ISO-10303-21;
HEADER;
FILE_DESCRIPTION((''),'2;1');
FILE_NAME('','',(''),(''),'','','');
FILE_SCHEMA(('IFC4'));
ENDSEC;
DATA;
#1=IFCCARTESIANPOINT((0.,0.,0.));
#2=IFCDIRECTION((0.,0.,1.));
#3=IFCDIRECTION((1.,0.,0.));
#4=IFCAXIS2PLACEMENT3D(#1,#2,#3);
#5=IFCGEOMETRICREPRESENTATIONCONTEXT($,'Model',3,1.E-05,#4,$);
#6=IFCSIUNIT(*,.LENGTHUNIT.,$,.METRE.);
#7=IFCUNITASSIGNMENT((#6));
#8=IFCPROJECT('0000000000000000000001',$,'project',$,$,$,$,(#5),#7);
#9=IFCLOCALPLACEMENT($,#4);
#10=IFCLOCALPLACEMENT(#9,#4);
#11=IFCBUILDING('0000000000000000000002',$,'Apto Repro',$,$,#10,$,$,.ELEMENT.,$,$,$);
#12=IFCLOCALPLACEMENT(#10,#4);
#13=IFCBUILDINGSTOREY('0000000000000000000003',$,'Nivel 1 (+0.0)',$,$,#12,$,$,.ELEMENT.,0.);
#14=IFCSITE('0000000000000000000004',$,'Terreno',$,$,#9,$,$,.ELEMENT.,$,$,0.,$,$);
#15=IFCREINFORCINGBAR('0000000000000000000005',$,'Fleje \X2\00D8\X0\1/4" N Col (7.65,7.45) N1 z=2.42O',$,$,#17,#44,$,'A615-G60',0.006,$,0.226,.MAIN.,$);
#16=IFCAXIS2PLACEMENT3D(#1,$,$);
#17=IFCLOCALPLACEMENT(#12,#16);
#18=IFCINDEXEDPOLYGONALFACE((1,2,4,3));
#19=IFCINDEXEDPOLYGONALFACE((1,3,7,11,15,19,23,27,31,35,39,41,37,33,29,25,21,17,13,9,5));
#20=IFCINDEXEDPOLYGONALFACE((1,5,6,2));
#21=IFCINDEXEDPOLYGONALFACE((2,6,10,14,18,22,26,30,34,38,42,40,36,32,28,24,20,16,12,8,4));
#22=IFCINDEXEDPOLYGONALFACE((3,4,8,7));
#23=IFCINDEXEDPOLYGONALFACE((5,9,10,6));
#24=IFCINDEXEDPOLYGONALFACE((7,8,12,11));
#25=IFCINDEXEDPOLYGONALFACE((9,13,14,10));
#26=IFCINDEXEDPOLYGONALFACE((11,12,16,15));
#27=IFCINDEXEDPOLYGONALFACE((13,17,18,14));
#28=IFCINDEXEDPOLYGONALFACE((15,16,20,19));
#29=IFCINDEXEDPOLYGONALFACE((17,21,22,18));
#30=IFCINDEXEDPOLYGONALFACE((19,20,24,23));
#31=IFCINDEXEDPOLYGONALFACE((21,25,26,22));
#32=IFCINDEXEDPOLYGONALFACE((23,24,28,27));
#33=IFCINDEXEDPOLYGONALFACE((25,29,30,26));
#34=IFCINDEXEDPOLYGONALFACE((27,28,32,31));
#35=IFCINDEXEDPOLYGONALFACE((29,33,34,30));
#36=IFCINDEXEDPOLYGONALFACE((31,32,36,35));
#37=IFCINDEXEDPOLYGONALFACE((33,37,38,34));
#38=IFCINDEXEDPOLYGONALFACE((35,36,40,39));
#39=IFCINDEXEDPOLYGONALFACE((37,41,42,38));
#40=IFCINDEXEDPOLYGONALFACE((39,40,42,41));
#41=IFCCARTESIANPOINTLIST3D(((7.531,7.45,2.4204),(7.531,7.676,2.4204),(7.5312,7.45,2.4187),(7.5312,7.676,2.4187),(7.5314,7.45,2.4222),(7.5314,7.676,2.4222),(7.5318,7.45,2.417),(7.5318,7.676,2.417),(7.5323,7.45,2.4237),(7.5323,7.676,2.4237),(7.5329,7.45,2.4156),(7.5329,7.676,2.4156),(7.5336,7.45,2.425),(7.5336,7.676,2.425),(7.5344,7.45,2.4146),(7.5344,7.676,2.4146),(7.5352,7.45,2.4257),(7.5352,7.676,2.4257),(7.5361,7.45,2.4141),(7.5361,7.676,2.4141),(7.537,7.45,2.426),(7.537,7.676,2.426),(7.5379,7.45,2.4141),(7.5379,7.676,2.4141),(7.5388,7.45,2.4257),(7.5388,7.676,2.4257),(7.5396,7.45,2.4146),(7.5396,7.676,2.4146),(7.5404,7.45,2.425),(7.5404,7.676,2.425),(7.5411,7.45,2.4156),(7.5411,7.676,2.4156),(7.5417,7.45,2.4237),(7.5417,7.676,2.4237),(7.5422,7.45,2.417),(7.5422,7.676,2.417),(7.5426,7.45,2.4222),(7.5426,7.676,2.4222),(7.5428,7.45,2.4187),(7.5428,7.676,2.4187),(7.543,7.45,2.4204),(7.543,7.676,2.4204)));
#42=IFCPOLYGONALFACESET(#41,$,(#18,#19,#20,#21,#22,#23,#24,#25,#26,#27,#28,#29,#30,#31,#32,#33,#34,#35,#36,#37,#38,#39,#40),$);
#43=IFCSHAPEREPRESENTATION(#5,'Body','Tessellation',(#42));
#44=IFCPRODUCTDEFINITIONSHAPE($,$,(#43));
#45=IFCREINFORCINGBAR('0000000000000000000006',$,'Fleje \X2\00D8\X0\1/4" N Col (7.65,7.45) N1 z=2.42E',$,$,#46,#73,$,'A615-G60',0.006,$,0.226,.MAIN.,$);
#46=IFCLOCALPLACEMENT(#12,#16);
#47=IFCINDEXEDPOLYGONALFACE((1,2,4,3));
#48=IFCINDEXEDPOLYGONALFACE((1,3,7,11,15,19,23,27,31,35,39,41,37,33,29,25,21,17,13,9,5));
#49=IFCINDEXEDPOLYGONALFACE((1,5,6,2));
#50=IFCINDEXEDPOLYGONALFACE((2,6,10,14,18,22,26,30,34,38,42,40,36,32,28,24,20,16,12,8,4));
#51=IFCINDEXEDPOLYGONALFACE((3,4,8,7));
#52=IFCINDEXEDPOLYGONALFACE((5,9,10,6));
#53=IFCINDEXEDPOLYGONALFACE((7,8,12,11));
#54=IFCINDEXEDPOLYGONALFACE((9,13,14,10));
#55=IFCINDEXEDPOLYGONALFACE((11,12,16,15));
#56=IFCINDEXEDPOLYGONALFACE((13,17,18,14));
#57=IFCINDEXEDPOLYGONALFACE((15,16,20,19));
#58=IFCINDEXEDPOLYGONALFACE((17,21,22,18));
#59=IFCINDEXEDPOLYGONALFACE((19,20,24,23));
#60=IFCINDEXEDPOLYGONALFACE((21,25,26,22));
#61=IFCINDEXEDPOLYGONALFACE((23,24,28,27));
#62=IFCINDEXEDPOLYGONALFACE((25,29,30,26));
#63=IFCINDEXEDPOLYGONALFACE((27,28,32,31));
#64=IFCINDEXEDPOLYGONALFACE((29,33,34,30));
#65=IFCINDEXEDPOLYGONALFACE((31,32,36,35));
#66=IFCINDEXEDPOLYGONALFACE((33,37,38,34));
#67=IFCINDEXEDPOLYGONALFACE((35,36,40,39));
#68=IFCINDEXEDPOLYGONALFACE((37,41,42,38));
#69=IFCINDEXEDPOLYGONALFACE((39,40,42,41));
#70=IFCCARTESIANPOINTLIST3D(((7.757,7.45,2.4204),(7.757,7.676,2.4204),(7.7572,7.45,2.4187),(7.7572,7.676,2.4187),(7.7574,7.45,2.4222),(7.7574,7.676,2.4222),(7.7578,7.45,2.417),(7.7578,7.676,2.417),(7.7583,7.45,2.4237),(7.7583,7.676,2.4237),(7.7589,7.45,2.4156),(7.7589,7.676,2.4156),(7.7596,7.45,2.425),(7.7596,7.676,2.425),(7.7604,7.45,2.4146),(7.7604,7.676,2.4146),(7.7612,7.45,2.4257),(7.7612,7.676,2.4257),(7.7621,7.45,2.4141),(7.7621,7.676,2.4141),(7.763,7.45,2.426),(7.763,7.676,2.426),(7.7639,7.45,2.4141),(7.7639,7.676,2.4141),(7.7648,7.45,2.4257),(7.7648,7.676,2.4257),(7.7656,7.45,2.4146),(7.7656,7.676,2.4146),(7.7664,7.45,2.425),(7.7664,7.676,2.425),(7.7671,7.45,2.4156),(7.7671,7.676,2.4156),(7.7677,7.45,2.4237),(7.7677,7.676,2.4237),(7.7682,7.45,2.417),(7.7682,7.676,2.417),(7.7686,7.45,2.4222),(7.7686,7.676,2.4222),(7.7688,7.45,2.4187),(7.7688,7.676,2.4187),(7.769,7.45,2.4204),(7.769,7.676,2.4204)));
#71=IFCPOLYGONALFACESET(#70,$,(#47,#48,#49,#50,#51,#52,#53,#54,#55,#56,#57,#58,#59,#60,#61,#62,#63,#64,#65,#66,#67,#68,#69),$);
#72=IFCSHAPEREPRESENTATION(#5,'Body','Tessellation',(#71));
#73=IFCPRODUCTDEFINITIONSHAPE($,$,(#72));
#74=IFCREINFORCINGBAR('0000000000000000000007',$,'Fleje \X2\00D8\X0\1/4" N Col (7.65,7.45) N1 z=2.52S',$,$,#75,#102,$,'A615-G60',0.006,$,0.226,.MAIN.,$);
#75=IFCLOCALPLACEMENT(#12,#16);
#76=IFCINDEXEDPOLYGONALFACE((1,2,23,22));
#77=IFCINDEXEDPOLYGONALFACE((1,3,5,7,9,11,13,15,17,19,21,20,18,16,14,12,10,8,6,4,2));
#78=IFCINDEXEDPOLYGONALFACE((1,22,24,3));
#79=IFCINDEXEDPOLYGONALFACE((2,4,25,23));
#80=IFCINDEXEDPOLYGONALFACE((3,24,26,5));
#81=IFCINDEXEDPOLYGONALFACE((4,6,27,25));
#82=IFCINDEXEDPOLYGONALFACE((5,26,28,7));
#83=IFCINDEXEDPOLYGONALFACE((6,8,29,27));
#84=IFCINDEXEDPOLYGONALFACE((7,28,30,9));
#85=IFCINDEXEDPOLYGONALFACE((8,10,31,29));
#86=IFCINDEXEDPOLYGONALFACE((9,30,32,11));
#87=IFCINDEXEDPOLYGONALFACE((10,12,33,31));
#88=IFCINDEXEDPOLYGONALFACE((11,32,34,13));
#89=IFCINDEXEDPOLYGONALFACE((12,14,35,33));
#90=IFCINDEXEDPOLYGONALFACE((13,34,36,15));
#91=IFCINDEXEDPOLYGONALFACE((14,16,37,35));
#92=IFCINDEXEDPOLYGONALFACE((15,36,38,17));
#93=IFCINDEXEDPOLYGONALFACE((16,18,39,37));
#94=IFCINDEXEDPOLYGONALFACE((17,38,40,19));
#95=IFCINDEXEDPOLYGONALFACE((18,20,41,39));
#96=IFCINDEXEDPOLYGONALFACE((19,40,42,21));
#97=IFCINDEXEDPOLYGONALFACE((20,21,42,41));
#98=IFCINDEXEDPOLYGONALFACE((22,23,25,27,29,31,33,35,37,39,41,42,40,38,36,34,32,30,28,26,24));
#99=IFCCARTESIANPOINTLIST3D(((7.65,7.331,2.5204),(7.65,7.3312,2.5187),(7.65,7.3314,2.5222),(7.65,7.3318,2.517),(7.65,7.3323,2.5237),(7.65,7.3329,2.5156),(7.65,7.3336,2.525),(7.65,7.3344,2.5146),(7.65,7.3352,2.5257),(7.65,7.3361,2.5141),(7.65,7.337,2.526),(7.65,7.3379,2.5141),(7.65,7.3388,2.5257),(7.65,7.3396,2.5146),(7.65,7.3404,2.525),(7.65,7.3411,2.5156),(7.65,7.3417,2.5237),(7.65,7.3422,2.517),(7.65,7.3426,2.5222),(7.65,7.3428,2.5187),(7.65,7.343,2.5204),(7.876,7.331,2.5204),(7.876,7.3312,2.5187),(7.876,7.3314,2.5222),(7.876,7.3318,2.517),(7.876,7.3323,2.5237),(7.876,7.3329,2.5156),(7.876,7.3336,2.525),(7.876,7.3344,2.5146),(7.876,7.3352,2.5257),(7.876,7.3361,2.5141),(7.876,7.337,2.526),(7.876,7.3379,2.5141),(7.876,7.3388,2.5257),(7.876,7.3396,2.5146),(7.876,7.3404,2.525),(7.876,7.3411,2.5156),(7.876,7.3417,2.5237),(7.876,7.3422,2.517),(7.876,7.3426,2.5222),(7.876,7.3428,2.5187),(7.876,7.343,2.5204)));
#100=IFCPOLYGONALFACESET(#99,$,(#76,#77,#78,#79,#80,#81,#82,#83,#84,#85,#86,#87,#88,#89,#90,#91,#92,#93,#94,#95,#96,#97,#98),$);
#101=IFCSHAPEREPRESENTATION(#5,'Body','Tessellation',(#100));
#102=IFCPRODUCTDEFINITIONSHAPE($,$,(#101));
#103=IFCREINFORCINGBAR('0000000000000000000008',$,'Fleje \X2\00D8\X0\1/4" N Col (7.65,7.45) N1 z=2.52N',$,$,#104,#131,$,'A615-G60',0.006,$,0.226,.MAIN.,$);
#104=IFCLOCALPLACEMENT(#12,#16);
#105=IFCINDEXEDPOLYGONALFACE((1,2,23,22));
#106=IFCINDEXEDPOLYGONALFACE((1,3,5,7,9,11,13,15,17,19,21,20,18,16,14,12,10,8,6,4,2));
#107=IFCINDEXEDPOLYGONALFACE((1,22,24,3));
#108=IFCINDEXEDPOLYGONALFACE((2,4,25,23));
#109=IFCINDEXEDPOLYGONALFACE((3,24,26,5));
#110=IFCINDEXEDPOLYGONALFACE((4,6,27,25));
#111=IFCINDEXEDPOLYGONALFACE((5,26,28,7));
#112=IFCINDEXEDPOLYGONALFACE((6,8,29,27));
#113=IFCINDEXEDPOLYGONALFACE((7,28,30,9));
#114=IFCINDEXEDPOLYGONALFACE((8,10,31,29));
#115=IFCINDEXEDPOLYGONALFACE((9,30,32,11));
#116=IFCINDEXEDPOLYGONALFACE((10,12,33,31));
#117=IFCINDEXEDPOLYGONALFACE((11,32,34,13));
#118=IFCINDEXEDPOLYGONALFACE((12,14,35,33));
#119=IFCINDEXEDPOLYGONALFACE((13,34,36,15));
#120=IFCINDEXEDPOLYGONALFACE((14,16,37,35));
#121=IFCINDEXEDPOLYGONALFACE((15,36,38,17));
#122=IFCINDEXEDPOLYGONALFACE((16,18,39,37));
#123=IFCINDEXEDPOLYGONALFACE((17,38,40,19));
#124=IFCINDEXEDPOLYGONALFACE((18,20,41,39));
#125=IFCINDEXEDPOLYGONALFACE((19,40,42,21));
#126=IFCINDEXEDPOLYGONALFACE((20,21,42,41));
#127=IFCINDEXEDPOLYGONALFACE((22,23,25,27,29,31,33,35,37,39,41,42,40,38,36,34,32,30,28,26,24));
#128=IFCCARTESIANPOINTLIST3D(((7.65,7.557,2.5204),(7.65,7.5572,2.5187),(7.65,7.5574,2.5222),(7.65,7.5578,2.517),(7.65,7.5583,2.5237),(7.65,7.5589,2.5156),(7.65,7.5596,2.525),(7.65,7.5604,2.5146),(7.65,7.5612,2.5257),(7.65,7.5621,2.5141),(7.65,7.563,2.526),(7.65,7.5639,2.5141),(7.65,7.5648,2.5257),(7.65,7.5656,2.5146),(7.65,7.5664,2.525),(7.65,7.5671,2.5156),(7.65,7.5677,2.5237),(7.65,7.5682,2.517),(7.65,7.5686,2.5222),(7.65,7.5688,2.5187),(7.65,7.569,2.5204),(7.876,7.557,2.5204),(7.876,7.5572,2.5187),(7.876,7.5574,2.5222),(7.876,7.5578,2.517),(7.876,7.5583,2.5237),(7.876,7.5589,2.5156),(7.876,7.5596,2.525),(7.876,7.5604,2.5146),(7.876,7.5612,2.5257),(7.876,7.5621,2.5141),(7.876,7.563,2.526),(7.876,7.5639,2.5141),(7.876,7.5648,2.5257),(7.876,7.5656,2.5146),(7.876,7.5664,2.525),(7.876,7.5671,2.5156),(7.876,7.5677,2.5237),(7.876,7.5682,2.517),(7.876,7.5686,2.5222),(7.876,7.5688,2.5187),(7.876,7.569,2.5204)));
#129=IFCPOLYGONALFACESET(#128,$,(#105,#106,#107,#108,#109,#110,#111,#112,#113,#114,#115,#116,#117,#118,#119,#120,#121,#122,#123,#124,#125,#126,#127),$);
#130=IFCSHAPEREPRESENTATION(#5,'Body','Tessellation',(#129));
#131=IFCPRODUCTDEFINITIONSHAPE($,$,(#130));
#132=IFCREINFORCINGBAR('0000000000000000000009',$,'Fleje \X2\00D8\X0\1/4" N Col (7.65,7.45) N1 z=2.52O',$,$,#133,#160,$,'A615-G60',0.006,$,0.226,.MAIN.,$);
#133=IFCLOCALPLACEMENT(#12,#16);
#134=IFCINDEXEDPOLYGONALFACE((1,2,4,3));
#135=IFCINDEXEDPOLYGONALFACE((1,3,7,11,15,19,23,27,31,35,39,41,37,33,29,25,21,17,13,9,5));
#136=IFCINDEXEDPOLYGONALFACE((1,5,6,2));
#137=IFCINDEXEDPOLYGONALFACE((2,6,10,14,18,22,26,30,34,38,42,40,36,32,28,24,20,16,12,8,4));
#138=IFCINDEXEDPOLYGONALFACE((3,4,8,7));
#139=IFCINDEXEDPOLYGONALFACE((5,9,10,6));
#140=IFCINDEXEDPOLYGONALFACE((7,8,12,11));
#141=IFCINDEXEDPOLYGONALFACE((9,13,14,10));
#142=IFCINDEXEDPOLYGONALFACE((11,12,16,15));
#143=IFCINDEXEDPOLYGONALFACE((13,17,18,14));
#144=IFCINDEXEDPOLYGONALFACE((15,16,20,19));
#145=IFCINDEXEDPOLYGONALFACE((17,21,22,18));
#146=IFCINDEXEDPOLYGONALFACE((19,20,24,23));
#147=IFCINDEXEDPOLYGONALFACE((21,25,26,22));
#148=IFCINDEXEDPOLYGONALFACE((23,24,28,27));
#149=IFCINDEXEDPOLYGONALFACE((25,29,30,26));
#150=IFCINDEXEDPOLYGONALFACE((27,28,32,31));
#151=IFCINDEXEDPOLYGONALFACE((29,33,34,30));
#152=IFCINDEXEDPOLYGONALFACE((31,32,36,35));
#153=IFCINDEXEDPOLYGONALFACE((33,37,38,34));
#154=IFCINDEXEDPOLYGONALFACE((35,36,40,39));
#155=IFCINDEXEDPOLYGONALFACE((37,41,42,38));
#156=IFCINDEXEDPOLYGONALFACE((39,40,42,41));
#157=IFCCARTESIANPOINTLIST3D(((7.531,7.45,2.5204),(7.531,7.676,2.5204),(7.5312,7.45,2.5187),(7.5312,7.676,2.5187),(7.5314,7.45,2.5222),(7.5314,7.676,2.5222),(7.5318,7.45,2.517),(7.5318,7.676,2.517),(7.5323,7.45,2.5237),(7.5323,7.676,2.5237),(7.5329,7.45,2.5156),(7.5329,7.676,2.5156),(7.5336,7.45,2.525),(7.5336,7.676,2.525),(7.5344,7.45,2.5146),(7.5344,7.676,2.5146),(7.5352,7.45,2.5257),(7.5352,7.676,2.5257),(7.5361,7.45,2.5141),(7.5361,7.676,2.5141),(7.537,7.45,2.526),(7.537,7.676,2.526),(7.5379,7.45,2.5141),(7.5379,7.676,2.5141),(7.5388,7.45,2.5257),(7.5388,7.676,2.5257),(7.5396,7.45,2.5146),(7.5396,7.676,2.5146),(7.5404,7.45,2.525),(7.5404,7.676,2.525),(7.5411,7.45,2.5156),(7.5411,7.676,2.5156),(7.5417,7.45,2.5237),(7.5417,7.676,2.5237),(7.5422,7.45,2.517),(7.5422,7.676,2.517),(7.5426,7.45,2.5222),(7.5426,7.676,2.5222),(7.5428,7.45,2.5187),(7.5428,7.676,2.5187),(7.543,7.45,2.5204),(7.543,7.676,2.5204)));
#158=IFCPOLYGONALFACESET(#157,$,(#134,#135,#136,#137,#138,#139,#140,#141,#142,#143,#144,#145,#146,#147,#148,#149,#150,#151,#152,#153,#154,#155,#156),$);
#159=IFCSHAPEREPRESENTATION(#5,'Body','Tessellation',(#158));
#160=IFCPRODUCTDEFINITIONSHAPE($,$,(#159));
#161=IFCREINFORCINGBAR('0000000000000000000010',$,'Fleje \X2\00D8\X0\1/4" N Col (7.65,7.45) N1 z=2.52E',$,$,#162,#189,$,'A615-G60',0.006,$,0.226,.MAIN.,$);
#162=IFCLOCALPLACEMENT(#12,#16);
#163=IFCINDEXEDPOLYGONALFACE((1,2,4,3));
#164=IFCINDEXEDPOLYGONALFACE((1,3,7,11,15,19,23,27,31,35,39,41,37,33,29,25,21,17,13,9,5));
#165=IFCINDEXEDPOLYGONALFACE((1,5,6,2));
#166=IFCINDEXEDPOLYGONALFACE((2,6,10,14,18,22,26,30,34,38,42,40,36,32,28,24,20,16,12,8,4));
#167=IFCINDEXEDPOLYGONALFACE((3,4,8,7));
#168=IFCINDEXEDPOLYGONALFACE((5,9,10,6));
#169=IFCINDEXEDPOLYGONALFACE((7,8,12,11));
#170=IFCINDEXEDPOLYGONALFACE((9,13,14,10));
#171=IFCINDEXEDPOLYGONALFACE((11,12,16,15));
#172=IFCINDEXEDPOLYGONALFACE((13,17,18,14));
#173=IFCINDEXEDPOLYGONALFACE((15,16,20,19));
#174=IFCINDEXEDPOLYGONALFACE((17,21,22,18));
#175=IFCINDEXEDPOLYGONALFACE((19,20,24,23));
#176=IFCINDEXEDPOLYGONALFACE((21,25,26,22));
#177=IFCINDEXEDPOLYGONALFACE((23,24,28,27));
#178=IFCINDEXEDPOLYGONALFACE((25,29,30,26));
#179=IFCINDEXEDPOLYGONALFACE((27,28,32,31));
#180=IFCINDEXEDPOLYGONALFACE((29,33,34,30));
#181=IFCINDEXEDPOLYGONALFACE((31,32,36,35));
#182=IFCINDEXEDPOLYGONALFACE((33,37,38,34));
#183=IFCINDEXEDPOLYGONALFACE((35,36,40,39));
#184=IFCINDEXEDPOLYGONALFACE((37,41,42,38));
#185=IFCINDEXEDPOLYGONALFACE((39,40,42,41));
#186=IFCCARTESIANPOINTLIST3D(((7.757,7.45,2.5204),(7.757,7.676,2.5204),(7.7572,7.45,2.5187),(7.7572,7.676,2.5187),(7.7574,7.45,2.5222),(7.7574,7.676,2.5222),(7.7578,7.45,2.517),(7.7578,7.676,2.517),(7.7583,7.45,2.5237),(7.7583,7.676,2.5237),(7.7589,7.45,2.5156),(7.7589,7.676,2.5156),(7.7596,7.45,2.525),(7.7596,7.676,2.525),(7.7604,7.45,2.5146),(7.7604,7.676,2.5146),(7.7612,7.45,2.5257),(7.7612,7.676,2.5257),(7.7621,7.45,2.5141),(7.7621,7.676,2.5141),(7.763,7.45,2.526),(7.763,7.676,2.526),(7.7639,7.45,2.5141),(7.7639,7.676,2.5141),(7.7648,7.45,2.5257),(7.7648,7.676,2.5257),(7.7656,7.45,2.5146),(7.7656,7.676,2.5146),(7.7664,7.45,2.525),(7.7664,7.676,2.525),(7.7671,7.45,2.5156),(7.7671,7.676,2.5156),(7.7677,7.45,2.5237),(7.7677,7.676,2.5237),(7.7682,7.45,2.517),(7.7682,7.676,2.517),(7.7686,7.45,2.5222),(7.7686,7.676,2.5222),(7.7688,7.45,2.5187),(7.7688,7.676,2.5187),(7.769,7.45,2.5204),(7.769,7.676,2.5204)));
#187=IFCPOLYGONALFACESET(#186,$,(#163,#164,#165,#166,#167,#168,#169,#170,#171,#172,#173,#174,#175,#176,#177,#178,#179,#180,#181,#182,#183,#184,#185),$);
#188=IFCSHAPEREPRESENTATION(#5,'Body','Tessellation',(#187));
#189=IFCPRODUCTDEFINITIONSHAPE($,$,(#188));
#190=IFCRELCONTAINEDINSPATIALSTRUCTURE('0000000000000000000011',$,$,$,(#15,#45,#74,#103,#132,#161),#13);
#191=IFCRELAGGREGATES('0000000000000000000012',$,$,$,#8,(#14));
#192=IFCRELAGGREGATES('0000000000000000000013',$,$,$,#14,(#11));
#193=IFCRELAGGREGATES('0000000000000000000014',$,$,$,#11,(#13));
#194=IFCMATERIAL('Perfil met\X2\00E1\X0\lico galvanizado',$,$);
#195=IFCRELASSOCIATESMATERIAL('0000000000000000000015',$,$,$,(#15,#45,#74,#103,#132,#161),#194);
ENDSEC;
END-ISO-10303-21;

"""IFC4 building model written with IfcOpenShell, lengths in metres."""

from ifc_helpers import new_model, si_unit, frame, origin_with_axes, origin_2d_with_axis, place, context, project, spatial, circle, extrude, material, element, save


model = new_model("IFC4")

# Units and contexts
model_context = context("Model", 3, precision=1e-05, world=origin_with_axes())
ifc_project = project(units=[si_unit("LENGTHUNIT", "METRE")], contexts=[model_context])

# Site, building, storey
site_placement = place(None, origin_with_axes())
site = spatial("IfcSite", under=ifc_project, at=site_placement, Name="Terreno", CompositionType="ELEMENT", RefElevation=0.0)
building_placement = place(site_placement, origin_with_axes())
building = spatial("IfcBuilding", under=site, at=building_placement, Name="Apto Repro", CompositionType="ELEMENT")
storey_placement = place(building_placement, origin_with_axes())
storey = spatial("IfcBuildingStorey", under=building, at=storey_placement, Name="Nivel 1 (+0.0)", CompositionType="ELEMENT", Elevation=0.0)

# Reinforcing bars
ifc_material = material(Name="Perfil metálico galvanizado")
reinforcing_bar_1_placement = place(storey_placement, origin_with_axes())
element("IfcReinforcingBar", 1, at=reinforcing_bar_1_placement, inside=storey, material=ifc_material, Name="Fleje Ø1/4\" N Col (7.65,7.45) N1 z=2.42O", SteelGrade="A615-G60", BarLength=0.226, NominalDiameter=0.006, PredefinedType="MAIN", context=model_context, shape_type="SweptSolid", body=[
    extrude(circle(Radius=0.006, at=origin_2d_with_axis()), frame((7.537, 7.45, 2.42), z_axis=(0.0, 1.0, 0.0), x_axis=(0.0, 0.0, 1.0)), (0.0, 0.0, 1.0), 0.226),
])
reinforcing_bar_2_placement = place(storey_placement, origin_with_axes())
element("IfcReinforcingBar", 2, at=reinforcing_bar_2_placement, inside=storey, material=ifc_material, Name="Fleje Ø1/4\" N Col (7.65,7.45) N1 z=2.42E", SteelGrade="A615-G60", BarLength=0.226, NominalDiameter=0.006, PredefinedType="MAIN", context=model_context, shape_type="SweptSolid", body=[
    extrude(circle(Radius=0.006, at=origin_2d_with_axis()), frame((7.763, 7.45, 2.42), z_axis=(0.0, 1.0, 0.0), x_axis=(0.0, 0.0, 1.0)), (0.0, 0.0, 1.0), 0.226),
])
reinforcing_bar_3_placement = place(storey_placement, origin_with_axes())
element("IfcReinforcingBar", 3, at=reinforcing_bar_3_placement, inside=storey, material=ifc_material, Name="Fleje Ø1/4\" N Col (7.65,7.45) N1 z=2.52S", SteelGrade="A615-G60", BarLength=0.226, NominalDiameter=0.006, PredefinedType="MAIN", context=model_context, shape_type="SweptSolid", body=[
    extrude(circle(Radius=0.006, at=origin_2d_with_axis()), frame((7.65, 7.337, 2.52), z_axis=(1.0, 0.0, 0.0), x_axis=(0.0, 0.0, 1.0)), (0.0, 0.0, 1.0), 0.226),
])
reinforcing_bar_4_placement = place(storey_placement, origin_with_axes())
element("IfcReinforcingBar", 4, at=reinforcing_bar_4_placement, inside=storey, material=ifc_material, Name="Fleje Ø1/4\" N Col (7.65,7.45) N1 z=2.52N", SteelGrade="A615-G60", BarLength=0.226, NominalDiameter=0.006, PredefinedType="MAIN", context=model_context, shape_type="SweptSolid", body=[
    extrude(circle(Radius=0.006, at=origin_2d_with_axis()), frame((7.65, 7.563, 2.52), z_axis=(1.0, 0.0, 0.0), x_axis=(0.0, 0.0, 1.0)), (0.0, 0.0, 1.0), 0.226),
])
reinforcing_bar_5_placement = place(storey_placement, origin_with_axes())
element("IfcReinforcingBar", 5, at=reinforcing_bar_5_placement, inside=storey, material=ifc_material, Name="Fleje Ø1/4\" N Col (7.65,7.45) N1 z=2.52O", SteelGrade="A615-G60", BarLength=0.226, NominalDiameter=0.006, PredefinedType="MAIN", context=model_context, shape_type="SweptSolid", body=[
    extrude(circle(Radius=0.006, at=origin_2d_with_axis()), frame((7.537, 7.45, 2.52), z_axis=(0.0, 1.0, 0.0), x_axis=(0.0, 0.0, 1.0)), (0.0, 0.0, 1.0), 0.226),
])
reinforcing_bar_6_placement = place(storey_placement, origin_with_axes())
element("IfcReinforcingBar", 6, at=reinforcing_bar_6_placement, inside=storey, material=ifc_material, Name="Fleje Ø1/4\" N Col (7.65,7.45) N1 z=2.52E", SteelGrade="A615-G60", BarLength=0.226, NominalDiameter=0.006, PredefinedType="MAIN", context=model_context, shape_type="SweptSolid", body=[
    extrude(circle(Radius=0.006, at=origin_2d_with_axis()), frame((7.763, 7.45, 2.52), z_axis=(0.0, 1.0, 0.0), x_axis=(0.0, 0.0, 1.0)), (0.0, 0.0, 1.0), 0.226),
])

save(model, "model.ifc")
